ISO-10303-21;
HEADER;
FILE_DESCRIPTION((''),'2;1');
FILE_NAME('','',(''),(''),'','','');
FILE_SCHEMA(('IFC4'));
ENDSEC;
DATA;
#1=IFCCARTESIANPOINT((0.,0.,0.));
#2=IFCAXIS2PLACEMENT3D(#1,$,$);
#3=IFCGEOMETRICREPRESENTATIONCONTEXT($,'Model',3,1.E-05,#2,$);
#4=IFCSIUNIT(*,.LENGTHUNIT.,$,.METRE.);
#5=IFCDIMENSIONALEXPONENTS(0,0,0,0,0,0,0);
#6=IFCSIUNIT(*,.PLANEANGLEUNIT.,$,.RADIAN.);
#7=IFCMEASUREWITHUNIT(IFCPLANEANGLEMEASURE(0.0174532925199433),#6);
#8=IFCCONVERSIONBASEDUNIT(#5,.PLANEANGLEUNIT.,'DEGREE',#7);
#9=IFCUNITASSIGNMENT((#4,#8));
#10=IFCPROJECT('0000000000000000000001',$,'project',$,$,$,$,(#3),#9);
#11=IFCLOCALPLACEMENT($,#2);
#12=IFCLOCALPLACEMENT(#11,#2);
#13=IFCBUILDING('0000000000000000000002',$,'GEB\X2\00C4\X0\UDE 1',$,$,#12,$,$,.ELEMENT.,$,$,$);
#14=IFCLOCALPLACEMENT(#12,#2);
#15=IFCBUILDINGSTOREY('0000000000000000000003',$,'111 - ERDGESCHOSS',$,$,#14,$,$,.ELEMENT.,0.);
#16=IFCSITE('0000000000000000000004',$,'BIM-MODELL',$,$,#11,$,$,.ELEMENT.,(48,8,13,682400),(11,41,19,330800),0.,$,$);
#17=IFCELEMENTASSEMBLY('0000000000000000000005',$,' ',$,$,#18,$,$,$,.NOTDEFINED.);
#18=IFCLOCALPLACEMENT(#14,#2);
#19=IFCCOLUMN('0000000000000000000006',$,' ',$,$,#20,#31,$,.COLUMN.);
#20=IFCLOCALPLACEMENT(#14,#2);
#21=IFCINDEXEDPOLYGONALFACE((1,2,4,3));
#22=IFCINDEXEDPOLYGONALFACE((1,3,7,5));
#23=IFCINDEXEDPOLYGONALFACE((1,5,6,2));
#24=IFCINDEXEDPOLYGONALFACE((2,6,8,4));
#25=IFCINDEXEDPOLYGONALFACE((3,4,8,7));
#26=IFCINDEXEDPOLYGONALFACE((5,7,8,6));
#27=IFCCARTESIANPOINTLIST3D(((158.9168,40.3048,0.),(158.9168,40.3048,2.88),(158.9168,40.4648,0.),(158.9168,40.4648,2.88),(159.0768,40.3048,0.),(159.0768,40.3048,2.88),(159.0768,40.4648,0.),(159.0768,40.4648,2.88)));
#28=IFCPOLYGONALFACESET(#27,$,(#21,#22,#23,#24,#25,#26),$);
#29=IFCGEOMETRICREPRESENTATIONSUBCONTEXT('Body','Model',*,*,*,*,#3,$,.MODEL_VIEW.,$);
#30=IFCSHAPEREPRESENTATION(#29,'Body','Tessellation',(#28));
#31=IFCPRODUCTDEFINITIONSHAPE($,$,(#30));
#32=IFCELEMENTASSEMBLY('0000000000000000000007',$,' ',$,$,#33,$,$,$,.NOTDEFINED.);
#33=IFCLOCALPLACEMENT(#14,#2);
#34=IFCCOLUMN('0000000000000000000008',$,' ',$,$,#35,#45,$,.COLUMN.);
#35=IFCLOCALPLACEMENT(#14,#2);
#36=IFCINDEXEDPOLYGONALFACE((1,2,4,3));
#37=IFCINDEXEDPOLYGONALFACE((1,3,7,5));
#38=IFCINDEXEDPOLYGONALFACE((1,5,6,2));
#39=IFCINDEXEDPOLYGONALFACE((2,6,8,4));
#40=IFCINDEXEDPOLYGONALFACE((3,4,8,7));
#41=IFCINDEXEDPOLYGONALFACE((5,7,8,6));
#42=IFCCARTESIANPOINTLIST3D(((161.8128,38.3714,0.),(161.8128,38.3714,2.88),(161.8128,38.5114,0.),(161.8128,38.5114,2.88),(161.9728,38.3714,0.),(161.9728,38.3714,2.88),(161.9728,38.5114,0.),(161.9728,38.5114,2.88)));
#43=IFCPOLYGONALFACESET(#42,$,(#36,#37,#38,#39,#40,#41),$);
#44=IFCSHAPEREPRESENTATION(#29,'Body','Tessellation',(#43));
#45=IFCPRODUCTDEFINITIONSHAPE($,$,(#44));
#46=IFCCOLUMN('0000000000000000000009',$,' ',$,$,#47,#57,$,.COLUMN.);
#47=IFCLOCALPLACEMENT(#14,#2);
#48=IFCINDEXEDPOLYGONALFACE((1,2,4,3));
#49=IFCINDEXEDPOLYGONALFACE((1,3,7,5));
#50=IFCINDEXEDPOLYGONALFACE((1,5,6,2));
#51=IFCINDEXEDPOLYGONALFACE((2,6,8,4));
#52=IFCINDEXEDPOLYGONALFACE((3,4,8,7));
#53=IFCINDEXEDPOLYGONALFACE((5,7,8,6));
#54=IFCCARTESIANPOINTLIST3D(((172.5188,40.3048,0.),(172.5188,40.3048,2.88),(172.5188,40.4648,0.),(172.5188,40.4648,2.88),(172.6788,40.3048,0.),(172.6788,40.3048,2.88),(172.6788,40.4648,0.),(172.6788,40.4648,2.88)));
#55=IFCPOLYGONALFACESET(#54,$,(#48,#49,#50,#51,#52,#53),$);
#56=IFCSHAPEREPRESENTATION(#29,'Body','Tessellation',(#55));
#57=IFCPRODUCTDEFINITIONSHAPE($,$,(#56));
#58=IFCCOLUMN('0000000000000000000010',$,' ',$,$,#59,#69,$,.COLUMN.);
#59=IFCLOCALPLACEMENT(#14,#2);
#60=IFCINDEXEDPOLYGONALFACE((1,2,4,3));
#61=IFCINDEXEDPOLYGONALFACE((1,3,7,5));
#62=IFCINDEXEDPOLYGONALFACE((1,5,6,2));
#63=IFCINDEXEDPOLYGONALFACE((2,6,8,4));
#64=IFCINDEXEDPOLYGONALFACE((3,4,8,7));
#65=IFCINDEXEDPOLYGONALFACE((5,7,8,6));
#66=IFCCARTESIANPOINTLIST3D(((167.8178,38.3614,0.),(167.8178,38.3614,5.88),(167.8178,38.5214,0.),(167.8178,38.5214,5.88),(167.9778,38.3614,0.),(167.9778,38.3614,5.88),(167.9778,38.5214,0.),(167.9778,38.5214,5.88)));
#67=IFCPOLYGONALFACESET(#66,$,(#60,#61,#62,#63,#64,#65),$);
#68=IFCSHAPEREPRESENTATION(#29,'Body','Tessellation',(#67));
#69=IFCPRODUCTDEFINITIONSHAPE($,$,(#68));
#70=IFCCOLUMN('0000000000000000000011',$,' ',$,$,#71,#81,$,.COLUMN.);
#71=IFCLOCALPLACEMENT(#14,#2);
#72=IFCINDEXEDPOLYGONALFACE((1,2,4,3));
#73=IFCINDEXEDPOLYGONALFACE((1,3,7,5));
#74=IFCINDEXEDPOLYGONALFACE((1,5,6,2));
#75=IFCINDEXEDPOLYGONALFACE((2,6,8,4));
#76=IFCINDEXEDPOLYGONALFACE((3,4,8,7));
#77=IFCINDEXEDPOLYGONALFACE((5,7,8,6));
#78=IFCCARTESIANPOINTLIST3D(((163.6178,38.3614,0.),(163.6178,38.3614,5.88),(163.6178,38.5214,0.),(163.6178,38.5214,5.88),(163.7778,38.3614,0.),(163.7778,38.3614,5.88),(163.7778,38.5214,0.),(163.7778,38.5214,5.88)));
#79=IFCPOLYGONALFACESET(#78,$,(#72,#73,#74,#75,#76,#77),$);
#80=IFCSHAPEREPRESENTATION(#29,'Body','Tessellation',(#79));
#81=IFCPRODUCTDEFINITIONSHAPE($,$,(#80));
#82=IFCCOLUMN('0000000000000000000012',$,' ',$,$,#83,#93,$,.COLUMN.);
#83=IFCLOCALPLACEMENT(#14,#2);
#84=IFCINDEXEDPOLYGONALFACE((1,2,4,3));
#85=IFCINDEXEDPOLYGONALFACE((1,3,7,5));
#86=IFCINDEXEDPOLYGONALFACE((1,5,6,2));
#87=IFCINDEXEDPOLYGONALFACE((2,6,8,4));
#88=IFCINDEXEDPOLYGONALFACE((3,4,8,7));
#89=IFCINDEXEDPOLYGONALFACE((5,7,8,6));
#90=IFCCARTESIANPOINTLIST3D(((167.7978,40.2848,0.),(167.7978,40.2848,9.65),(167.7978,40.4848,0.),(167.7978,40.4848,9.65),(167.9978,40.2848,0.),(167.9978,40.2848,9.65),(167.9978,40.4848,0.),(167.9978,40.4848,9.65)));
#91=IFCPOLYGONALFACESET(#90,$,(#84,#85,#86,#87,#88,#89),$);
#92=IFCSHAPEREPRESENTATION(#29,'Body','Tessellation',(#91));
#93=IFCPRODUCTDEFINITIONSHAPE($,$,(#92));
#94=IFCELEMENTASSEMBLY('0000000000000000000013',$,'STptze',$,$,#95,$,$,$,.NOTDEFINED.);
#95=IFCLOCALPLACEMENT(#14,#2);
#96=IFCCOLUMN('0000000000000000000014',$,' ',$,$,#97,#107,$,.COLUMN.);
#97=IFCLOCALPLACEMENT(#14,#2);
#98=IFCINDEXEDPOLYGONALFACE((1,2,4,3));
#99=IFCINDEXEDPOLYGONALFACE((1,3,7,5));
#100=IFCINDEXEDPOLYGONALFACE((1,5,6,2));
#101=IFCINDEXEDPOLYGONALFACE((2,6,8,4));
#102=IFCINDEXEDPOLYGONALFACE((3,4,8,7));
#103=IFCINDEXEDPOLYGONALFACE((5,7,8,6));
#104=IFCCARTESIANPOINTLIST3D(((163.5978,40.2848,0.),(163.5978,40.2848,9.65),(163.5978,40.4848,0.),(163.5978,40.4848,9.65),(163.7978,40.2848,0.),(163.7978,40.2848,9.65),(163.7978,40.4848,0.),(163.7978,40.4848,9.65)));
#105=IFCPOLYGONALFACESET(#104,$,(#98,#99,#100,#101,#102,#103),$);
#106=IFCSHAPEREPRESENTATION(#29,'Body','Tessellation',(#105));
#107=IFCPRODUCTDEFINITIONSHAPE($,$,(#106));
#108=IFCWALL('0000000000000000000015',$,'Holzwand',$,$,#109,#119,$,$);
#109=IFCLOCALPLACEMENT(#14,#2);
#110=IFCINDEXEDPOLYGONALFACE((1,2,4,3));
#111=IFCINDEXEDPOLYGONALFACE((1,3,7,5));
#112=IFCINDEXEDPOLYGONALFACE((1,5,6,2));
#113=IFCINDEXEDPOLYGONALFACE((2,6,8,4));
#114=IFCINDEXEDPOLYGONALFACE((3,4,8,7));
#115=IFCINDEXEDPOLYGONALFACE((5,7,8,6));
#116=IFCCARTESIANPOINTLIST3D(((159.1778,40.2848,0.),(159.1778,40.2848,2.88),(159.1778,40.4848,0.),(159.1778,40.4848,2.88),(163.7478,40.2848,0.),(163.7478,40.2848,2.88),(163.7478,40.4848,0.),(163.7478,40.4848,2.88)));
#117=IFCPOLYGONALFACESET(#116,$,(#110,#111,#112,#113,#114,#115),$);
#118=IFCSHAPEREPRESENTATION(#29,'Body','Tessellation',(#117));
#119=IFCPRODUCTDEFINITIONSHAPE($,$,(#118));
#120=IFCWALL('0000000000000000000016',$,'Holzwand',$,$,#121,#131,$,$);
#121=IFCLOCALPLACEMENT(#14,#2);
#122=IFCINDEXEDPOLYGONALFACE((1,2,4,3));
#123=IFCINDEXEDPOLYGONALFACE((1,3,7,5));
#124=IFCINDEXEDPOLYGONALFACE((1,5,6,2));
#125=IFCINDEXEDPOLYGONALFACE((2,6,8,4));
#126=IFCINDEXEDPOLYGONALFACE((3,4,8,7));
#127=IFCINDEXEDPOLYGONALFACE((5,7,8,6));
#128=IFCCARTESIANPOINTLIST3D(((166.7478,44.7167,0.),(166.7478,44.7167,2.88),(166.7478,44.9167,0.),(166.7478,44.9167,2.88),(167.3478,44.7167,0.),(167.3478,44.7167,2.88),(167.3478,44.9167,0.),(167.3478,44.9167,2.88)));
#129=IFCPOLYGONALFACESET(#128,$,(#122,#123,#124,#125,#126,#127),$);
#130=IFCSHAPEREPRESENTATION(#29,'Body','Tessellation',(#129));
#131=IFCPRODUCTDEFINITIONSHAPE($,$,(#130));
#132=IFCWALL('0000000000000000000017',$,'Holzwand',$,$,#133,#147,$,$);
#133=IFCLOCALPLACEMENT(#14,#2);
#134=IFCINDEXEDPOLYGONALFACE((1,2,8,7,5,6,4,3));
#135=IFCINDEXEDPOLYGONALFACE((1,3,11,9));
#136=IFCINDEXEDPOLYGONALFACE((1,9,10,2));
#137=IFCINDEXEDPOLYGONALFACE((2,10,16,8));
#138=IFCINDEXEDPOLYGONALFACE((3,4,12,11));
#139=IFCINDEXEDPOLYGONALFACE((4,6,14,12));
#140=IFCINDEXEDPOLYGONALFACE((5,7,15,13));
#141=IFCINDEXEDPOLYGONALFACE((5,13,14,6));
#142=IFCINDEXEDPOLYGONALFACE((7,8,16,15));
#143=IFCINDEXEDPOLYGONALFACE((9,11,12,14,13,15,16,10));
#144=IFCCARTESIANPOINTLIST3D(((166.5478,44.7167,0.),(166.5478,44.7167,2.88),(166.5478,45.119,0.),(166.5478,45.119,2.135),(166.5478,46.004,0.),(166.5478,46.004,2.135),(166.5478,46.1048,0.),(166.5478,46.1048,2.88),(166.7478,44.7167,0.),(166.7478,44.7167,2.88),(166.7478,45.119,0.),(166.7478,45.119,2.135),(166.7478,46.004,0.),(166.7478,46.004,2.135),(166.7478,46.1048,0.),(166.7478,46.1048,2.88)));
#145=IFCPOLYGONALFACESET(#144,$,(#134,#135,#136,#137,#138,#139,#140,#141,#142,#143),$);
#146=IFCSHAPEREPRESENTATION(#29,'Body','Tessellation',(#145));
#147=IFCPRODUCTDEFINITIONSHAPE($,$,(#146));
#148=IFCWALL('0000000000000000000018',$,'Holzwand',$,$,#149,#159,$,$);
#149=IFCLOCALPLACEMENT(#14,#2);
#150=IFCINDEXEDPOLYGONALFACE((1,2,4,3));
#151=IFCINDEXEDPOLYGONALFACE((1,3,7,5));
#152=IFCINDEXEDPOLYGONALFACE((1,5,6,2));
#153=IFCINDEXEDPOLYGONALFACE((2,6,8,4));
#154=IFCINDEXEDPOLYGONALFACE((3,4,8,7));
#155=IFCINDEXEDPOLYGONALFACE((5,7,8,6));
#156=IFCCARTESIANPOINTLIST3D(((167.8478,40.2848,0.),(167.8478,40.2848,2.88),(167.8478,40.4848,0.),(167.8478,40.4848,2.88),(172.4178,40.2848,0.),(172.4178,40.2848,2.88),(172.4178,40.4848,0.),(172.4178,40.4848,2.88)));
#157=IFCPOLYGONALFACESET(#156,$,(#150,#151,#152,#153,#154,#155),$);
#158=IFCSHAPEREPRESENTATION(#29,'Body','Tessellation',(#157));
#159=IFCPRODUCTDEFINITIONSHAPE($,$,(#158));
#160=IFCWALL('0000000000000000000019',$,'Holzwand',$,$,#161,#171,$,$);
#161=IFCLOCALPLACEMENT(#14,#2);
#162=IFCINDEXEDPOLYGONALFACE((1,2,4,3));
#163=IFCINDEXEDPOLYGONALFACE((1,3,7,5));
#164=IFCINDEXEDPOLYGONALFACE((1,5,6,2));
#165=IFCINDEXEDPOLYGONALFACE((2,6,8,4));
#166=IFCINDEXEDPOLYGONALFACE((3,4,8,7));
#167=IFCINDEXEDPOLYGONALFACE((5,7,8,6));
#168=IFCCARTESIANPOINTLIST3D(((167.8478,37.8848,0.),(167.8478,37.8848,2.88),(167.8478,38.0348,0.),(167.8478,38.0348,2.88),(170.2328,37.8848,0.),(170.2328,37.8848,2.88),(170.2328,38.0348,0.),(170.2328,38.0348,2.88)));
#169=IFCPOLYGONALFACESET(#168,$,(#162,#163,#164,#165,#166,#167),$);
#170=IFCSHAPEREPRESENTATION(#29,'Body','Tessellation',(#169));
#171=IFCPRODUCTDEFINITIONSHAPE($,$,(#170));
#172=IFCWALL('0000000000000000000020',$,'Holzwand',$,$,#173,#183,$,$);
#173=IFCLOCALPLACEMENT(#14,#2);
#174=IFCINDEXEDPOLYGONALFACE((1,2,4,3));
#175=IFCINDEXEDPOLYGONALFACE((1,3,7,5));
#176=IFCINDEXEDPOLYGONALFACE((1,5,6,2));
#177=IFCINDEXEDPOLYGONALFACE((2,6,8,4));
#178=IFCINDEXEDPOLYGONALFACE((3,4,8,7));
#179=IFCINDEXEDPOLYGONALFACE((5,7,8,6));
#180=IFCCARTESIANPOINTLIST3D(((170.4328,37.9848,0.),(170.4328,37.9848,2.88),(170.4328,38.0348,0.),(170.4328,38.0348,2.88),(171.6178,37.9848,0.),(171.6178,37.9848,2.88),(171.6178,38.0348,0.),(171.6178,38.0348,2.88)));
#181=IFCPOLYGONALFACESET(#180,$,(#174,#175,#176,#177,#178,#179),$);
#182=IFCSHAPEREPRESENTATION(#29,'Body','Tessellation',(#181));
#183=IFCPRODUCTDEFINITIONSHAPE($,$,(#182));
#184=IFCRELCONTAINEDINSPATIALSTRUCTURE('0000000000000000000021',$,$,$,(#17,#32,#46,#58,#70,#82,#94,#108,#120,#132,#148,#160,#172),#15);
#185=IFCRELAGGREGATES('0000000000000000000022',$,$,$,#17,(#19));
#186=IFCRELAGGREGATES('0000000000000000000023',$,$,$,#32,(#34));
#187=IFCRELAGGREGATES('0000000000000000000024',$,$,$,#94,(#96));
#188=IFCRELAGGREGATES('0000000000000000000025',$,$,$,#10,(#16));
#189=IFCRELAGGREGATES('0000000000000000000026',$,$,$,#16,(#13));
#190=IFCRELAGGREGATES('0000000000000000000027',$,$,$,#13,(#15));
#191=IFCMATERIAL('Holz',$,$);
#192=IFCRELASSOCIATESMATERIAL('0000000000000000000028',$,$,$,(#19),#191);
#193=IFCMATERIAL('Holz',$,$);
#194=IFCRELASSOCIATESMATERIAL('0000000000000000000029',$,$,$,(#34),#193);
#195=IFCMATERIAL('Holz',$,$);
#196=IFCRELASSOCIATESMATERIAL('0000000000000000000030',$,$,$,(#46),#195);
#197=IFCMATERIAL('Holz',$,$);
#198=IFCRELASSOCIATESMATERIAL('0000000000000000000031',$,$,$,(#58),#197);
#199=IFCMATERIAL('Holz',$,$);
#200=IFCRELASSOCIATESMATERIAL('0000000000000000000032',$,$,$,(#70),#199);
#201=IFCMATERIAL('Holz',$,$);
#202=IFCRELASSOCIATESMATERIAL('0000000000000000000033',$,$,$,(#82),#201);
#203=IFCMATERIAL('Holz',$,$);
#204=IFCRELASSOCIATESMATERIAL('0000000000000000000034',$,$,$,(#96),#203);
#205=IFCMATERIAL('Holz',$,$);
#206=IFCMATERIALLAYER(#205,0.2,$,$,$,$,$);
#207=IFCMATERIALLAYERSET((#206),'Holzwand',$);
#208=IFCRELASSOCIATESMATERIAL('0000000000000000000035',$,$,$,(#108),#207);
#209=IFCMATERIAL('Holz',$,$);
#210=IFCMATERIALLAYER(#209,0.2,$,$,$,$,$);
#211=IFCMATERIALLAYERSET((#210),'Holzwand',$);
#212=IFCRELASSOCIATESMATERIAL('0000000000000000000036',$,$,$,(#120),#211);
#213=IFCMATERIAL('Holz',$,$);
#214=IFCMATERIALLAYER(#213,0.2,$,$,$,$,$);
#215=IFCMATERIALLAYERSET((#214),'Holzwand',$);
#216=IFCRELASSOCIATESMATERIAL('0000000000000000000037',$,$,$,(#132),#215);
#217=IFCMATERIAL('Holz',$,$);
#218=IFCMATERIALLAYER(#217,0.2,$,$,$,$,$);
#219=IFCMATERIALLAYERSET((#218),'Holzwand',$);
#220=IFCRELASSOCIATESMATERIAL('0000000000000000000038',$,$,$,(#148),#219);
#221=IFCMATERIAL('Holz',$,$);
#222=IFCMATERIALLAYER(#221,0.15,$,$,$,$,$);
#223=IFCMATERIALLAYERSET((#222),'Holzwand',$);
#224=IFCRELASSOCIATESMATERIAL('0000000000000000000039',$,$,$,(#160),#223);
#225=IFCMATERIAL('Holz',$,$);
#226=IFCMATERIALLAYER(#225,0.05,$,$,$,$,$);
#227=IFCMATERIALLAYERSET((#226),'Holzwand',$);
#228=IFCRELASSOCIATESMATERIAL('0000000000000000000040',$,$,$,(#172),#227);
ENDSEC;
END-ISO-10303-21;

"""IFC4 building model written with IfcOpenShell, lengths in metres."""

from ifc_helpers import new_model, entity, si_unit, converted_unit, frame, frame_2d, origin, origin_with_axes, place, context, subcontext, project, spatial, polyline, rectangle, outline, extrude, material, layer, layer_set, layer_usage, element, aggregate, save


model = new_model("IFC4")

# Units and contexts
model_context = context("Model", 3, precision=1e-05, world=origin())
body_context = subcontext(model_context, "Body", "Model", "MODEL_VIEW")
ifc_project = project(units=[si_unit("LENGTHUNIT", "METRE"), converted_unit("PLANEANGLEUNIT", "DEGREE", entity("IfcPlaneAngleMeasure", 0.0174532925199433), si_unit("PLANEANGLEUNIT", "RADIAN"), dimensions=[0, 0, 0, 0, 0, 0, 0])], contexts=[model_context])

# Site, building, storey
site_placement = place(None, origin())
site = spatial("IfcSite", under=ifc_project, at=site_placement, Name="BIM-MODELL", CompositionType="ELEMENT", RefLatitude=(48, 8, 13, 682400), RefLongitude=(11, 41, 19, 330800), RefElevation=0.0)
building_placement = place(site_placement, origin())
building = spatial("IfcBuilding", under=site, at=building_placement, Name="GEBÄUDE 1", CompositionType="ELEMENT")
storey_placement = place(building_placement, origin())
storey = spatial("IfcBuildingStorey", under=building, at=storey_placement, Name="111 - ERDGESCHOSS", CompositionType="ELEMENT", Elevation=0.0)

# Element assemblies, columns
assembly_1_placement = place(storey_placement, origin())
assembly_1 = element("IfcElementAssembly", 1, at=assembly_1_placement, inside=storey, Name=" ", PredefinedType="NOTDEFINED")
ifc_material_1 = material(Name="Holz")
column_1_placement = place(assembly_1_placement, frame((158.9168, 40.3048, 0.0)))
column_1 = element("IfcColumn", 2, at=column_1_placement, material=ifc_material_1, Name=" ", PredefinedType="COLUMN", context=body_context, shape_type="SweptSolid", body=[
    extrude(rectangle(XDim=0.16, YDim=0.16, at=frame_2d((0.08, 0.08), x_axis=(1.0, 0.0))), origin_with_axes(), (0.0, 0.0, 1.0), 2.88),
])
aggregate(assembly_1, [column_1])
assembly_2_placement = place(storey_placement, origin())
assembly_2 = element("IfcElementAssembly", 3, at=assembly_2_placement, inside=storey, Name=" ", PredefinedType="NOTDEFINED")
ifc_material_2 = material(Name="Holz")
column_2_placement = place(assembly_2_placement, frame((161.8128, 38.3714, 0.0)))
column_2 = element("IfcColumn", 4, at=column_2_placement, material=ifc_material_2, Name=" ", PredefinedType="COLUMN", context=body_context, shape_type="SweptSolid", body=[
    extrude(rectangle(XDim=0.16, YDim=0.14, at=frame_2d((0.08, 0.07), x_axis=(1.0, 0.0))), origin_with_axes(), (0.0, 0.0, 1.0), 2.88),
])
aggregate(assembly_2, [column_2])

# Columns
ifc_material_3 = material(Name="Holz")
column_3_placement = place(storey_placement, frame((172.5188, 40.3048, 0.0)))
element("IfcColumn", 5, at=column_3_placement, inside=storey, material=ifc_material_3, Name=" ", PredefinedType="COLUMN", context=body_context, shape_type="SweptSolid", body=[
    extrude(rectangle(XDim=0.16, YDim=0.16, at=frame_2d((0.08, 0.08), x_axis=(1.0, 0.0))), origin_with_axes(), (0.0, 0.0, 1.0), 2.88),
])
ifc_material_4 = material(Name="Holz")
column_4_placement = place(storey_placement, frame((167.8178, 38.3614, 0.0)))
element("IfcColumn", 6, at=column_4_placement, inside=storey, material=ifc_material_4, Name=" ", PredefinedType="COLUMN", context=body_context, shape_type="SweptSolid", body=[
    extrude(rectangle(XDim=0.16, YDim=0.16, at=frame_2d((0.08, 0.08), x_axis=(1.0, 0.0))), origin_with_axes(), (0.0, 0.0, 1.0), 5.88),
])
ifc_material_5 = material(Name="Holz")
column_5_placement = place(storey_placement, frame((163.6178, 38.3614, 0.0)))
element("IfcColumn", 7, at=column_5_placement, inside=storey, material=ifc_material_5, Name=" ", PredefinedType="COLUMN", context=body_context, shape_type="SweptSolid", body=[
    extrude(rectangle(XDim=0.16, YDim=0.16, at=frame_2d((0.08, 0.08), x_axis=(1.0, 0.0))), origin_with_axes(), (0.0, 0.0, 1.0), 5.88),
])
ifc_material_6 = material(Name="Holz")
column_6_placement = place(storey_placement, frame((167.7978, 40.2848, 0.0)))
element("IfcColumn", 8, at=column_6_placement, inside=storey, material=ifc_material_6, Name=" ", PredefinedType="COLUMN", context=body_context, shape_type="SweptSolid", body=[
    extrude(rectangle(XDim=0.2, YDim=0.2, at=frame_2d((0.1, 0.1), x_axis=(1.0, 0.0))), origin_with_axes(), (0.0, 0.0, 1.0), 9.65),
])

# Element assembly, column
assembly_3_placement = place(storey_placement, origin())
assembly_3 = element("IfcElementAssembly", 9, at=assembly_3_placement, inside=storey, Name="STptze", PredefinedType="NOTDEFINED")
ifc_material_7 = material(Name="Holz")
column_7_placement = place(assembly_3_placement, frame((163.5978, 40.2848, 0.0)))
column_7 = element("IfcColumn", 10, at=column_7_placement, material=ifc_material_7, Name=" ", PredefinedType="COLUMN", context=body_context, shape_type="SweptSolid", body=[
    extrude(rectangle(XDim=0.2, YDim=0.2, at=frame_2d((0.1, 0.1), x_axis=(1.0, 0.0))), origin_with_axes(), (0.0, 0.0, 1.0), 9.65),
])
aggregate(assembly_3, [column_7])

# Walls
ifc_material_8 = material(Name="Holz")
ifc_layer_1 = layer(ifc_material_8, 0.2)
ifc_layer_set_1 = layer_set([ifc_layer_1], Name="Holzwand")
ifc_layer_usage_1 = layer_usage(ifc_layer_set_1, "AXIS2", "POSITIVE", 0.0)
wall_1_placement = place(storey_placement, frame((163.7478, 40.4848, 0.0), z_axis=(0.0, 0.0, 1.0), x_axis=(-1.0, 0.0, 0.0)))
element("IfcWall", 11, at=wall_1_placement, inside=storey, material=ifc_layer_usage_1, Name="Holzwand", context=body_context, shape_type="SweptSolid", body=[
    extrude(rectangle(XDim=4.57, YDim=0.2, at=frame_2d((2.285, 0.1), x_axis=(1.0, 0.0))), origin_with_axes(), (0.0, 0.0, 1.0), 2.88),
])
ifc_material_9 = material(Name="Holz")
ifc_layer_2 = layer(ifc_material_9, 0.2)
ifc_layer_set_2 = layer_set([ifc_layer_2], Name="Holzwand")
ifc_layer_usage_2 = layer_usage(ifc_layer_set_2, "AXIS2", "POSITIVE", 0.0)
wall_2_placement = place(storey_placement, frame((166.7478, 44.7167, 0.0)))
element("IfcWall", 12, at=wall_2_placement, inside=storey, material=ifc_layer_usage_2, Name="Holzwand", context=body_context, shape_type="SweptSolid", body=[
    extrude(rectangle(XDim=0.6, YDim=0.2, at=frame_2d((0.3, 0.1), x_axis=(1.0, 0.0))), origin_with_axes(), (0.0, 0.0, 1.0), 2.88),
])

# Wall, opening
ifc_material_10 = material(Name="Holz")
ifc_layer_3 = layer(ifc_material_10, 0.2)
ifc_layer_set_3 = layer_set([ifc_layer_3], Name="Holzwand")
ifc_layer_usage_3 = layer_usage(ifc_layer_set_3, "AXIS2", "POSITIVE", 0.0)
wall_3_placement = place(storey_placement, frame((166.5478, 46.1048, 0.0), z_axis=(0.0, 0.0, 1.0), x_axis=(0.0, -1.0, 0.0)))
wall_3 = element("IfcWall", 13, at=wall_3_placement, inside=storey, material=ifc_layer_usage_3, Name="Holzwand", context=body_context, shape_type="SweptSolid", body=[
    extrude(rectangle(XDim=1.3881, YDim=0.2, at=frame_2d((0.6941, 0.1), x_axis=(1.0, 0.0))), origin_with_axes(), (0.0, 0.0, 1.0), 2.88),
])
opening_1_placement = place(wall_3_placement, frame((0.9858, 0.2, 0.0), z_axis=(0.0, -1.0, 0.0), x_axis=(0.0, 0.0, 1.0)))
element("IfcOpeningElement", 14, at=opening_1_placement, cuts=wall_3, ObjectType="Opening", context=body_context, shape_type="SweptSolid", body=[
    extrude(outline(polyline([(0.0, 0.885), (2.135, 0.885), (2.135, 0.0), (0.0, 0.0), (0.0, 0.885)])), origin_with_axes(), (0.0, 0.0, 1.0), 0.2),
])

# Walls
ifc_material_11 = material(Name="Holz")
ifc_layer_4 = layer(ifc_material_11, 0.2)
ifc_layer_set_4 = layer_set([ifc_layer_4], Name="Holzwand")
ifc_layer_usage_4 = layer_usage(ifc_layer_set_4, "AXIS2", "POSITIVE", 0.0)
wall_4_placement = place(storey_placement, frame((172.4178, 40.4848, 0.0), z_axis=(0.0, 0.0, 1.0), x_axis=(-1.0, 0.0, 0.0)))
element("IfcWall", 15, at=wall_4_placement, inside=storey, material=ifc_layer_usage_4, Name="Holzwand", context=body_context, shape_type="SweptSolid", body=[
    extrude(rectangle(XDim=4.57, YDim=0.2, at=frame_2d((2.285, 0.1), x_axis=(1.0, 0.0))), origin_with_axes(), (0.0, 0.0, 1.0), 2.88),
])
ifc_material_12 = material(Name="Holz")
ifc_layer_5 = layer(ifc_material_12, 0.15)
ifc_layer_set_5 = layer_set([ifc_layer_5], Name="Holzwand")
ifc_layer_usage_5 = layer_usage(ifc_layer_set_5, "AXIS2", "POSITIVE", 0.0)
wall_5_placement = place(storey_placement, frame((170.2328, 38.0348, 0.0), z_axis=(0.0, 0.0, 1.0), x_axis=(-1.0, 0.0, 0.0)))
element("IfcWall", 16, at=wall_5_placement, inside=storey, material=ifc_layer_usage_5, Name="Holzwand", context=body_context, shape_type="SweptSolid", body=[
    extrude(rectangle(XDim=2.385, YDim=0.15, at=frame_2d((1.1925, 0.075), x_axis=(1.0, 0.0))), origin_with_axes(), (0.0, 0.0, 1.0), 2.88),
])
ifc_material_13 = material(Name="Holz")
ifc_layer_6 = layer(ifc_material_13, 0.05)
ifc_layer_set_6 = layer_set([ifc_layer_6], Name="Holzwand")
ifc_layer_usage_6 = layer_usage(ifc_layer_set_6, "AXIS2", "POSITIVE", 0.0)
wall_6_placement = place(storey_placement, frame((170.4328, 37.9848, 0.0)))
element("IfcWall", 17, at=wall_6_placement, inside=storey, material=ifc_layer_usage_6, Name="Holzwand", context=body_context, shape_type="SweptSolid", body=[
    extrude(rectangle(XDim=1.185, YDim=0.05, at=frame_2d((0.5925, 0.025), x_axis=(1.0, 0.0))), origin_with_axes(), (0.0, 0.0, 1.0), 2.88),
])

save(model, "model.ifc")
